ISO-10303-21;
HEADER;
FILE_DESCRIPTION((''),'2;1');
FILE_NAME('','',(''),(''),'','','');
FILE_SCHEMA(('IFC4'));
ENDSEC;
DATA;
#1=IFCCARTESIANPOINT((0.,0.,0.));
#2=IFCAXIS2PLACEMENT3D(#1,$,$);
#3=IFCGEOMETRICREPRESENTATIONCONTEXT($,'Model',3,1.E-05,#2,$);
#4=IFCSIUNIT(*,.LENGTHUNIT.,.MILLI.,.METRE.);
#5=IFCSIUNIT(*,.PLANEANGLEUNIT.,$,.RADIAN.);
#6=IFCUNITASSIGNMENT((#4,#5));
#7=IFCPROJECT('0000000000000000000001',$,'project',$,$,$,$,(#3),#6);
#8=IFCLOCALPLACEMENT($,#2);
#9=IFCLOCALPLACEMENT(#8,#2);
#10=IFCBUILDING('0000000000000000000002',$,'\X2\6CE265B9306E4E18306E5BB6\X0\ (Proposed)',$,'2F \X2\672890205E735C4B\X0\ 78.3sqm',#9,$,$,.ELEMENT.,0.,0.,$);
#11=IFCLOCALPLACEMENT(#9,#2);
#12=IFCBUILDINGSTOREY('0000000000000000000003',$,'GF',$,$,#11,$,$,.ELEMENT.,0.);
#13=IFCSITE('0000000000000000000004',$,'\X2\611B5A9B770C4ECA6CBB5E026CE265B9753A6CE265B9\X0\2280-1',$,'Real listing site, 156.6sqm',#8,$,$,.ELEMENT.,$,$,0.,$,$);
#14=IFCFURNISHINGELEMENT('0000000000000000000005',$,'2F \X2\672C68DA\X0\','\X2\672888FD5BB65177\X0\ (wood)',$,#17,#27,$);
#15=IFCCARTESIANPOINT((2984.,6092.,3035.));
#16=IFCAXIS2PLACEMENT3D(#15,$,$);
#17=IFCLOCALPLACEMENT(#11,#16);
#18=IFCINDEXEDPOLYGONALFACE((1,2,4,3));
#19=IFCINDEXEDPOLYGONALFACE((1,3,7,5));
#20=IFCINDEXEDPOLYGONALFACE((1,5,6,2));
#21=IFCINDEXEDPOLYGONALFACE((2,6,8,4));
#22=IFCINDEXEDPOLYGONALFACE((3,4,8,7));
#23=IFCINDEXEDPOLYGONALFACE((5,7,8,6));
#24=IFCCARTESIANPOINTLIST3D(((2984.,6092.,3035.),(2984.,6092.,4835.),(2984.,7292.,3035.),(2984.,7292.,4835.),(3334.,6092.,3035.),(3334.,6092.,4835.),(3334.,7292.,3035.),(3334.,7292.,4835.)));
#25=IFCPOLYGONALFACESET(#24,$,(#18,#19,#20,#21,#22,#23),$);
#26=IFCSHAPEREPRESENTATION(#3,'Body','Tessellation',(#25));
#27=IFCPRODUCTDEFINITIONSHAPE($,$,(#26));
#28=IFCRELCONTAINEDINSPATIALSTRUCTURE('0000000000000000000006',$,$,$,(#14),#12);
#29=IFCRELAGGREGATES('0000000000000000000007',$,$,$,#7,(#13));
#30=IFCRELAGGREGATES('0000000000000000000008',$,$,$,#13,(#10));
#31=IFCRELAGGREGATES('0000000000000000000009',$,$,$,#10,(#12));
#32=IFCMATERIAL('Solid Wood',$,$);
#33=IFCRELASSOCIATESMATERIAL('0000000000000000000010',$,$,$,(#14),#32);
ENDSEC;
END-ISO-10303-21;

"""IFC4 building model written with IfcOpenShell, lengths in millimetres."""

from ifc_helpers import new_model, si_unit, frame, frame_2d, origin, place, context, project, spatial, rectangle, extrude, material, element, save


model = new_model("IFC4")

# Units and contexts
model_context = context("Model", 3, precision=1e-05, world=origin())
ifc_project = project(units=[si_unit("LENGTHUNIT", "METRE", prefix="MILLI"), si_unit("PLANEANGLEUNIT", "RADIAN")], contexts=[model_context])

# Site, building, storey
site_placement = place(None, origin())
site = spatial("IfcSite", under=ifc_project, at=site_placement, Name="愛媛県今治市波方町波方2280-1", ObjectType="Real listing site, 156.6sqm", CompositionType="ELEMENT", RefElevation=0.0)
building_placement = place(site_placement, origin())
building = spatial("IfcBuilding", under=site, at=building_placement, Name="波方の丘の家 (Proposed)", ObjectType="2F 木造平屋 78.3sqm", CompositionType="ELEMENT", ElevationOfRefHeight=0.0, ElevationOfTerrain=0.0)
storey_placement = place(building_placement, origin())
storey = spatial("IfcBuildingStorey", under=building, at=storey_placement, Name="GF", CompositionType="ELEMENT", Elevation=0.0)

# Shared definitions
ifc_material_1 = material(Name="Solid Wood")

# Furnishing element
furnishing_1_placement = place(storey_placement, frame((2984.0, 6092.0, 3035.0)))
element("IfcFurnishingElement", 1, at=furnishing_1_placement, inside=storey, material=ifc_material_1, Name="2F 本棚", Description="木製家具 (wood)", context=model_context, shape_type="SweptSolid", body=[
    extrude(rectangle(XDim=350.0, YDim=1200.0, at=frame_2d((175.0, 600.0))), frame((2984.0, 6092.0, 3035.0)), (0.0, 0.0, 1.0), 1800.0),
])

save(model, "model.ifc")
